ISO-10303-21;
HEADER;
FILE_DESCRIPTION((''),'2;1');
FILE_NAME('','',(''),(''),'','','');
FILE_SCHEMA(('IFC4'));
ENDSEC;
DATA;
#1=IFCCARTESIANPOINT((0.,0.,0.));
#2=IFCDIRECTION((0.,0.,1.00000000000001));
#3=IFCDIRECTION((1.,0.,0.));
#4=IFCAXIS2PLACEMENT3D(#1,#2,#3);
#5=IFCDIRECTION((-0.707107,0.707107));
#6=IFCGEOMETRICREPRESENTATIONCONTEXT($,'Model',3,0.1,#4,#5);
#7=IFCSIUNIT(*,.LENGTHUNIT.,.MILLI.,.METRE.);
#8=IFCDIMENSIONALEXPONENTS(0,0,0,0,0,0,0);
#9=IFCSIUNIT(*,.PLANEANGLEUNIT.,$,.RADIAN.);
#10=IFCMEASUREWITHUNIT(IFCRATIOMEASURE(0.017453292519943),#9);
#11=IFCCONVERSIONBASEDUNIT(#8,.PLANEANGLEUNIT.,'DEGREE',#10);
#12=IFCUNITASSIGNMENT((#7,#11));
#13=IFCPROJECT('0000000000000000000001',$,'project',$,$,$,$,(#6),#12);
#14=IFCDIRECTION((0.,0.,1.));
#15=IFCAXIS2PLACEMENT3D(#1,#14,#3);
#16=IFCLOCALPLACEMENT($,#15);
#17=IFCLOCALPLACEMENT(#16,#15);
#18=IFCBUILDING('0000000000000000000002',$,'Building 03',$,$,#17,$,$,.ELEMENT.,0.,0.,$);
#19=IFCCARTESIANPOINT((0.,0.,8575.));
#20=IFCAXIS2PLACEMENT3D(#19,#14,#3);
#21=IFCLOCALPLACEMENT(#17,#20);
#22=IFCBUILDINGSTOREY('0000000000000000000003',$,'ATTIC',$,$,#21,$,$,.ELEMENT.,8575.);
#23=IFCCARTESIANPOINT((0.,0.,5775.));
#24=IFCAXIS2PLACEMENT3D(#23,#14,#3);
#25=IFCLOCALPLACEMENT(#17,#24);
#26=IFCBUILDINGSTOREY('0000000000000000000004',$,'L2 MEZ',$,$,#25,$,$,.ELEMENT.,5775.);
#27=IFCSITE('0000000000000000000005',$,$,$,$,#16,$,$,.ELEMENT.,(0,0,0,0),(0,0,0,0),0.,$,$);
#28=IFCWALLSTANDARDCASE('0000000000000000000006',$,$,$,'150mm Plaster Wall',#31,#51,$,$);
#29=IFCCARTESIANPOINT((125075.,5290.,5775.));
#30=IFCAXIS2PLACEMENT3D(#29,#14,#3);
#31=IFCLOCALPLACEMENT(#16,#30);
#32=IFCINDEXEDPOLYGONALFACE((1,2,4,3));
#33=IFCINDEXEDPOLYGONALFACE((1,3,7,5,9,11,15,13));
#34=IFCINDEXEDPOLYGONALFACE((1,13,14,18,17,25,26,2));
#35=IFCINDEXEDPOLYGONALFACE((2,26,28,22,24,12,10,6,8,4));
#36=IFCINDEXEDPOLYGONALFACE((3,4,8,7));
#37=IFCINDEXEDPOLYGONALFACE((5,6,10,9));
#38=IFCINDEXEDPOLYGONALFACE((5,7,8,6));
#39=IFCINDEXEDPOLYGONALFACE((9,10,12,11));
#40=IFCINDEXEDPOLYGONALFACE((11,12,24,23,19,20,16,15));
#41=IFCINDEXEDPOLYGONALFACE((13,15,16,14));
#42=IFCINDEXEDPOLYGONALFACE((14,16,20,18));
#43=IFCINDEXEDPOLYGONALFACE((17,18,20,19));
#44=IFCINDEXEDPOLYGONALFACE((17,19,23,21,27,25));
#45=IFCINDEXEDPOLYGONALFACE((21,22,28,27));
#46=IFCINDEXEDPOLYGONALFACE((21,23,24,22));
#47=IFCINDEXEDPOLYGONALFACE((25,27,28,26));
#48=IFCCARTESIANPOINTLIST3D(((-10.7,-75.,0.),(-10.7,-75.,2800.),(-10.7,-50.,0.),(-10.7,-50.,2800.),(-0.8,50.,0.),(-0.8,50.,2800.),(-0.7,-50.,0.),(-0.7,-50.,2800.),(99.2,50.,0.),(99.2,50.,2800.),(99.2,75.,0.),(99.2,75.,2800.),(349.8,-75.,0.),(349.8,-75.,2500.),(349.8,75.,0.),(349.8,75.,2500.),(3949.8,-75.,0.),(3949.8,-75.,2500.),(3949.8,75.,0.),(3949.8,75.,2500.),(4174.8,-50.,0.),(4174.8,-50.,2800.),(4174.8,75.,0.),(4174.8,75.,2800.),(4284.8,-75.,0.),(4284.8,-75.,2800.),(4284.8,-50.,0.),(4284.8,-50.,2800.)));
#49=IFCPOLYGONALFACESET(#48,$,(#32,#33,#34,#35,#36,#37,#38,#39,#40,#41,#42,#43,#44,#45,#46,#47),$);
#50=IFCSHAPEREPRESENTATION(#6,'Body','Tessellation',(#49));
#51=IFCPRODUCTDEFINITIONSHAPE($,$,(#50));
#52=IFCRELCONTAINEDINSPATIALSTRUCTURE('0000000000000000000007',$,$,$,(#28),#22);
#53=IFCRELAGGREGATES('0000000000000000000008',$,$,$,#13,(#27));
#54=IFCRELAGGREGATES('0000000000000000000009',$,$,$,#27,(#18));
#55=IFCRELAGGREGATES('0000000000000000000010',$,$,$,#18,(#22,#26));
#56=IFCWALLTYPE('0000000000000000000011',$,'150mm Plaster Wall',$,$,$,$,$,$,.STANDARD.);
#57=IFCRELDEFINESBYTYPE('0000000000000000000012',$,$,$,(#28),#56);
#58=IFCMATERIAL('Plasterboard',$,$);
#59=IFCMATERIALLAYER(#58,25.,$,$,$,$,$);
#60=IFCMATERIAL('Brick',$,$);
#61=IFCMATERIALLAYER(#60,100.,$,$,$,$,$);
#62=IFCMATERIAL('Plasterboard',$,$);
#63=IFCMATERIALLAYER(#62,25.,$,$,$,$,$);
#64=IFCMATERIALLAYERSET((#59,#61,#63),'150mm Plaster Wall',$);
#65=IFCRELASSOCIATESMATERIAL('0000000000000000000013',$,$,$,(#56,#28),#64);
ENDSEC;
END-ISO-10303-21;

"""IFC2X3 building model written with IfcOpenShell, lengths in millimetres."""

from ifc_helpers import new_model, entity, si_unit, converted_unit, direction, frame, origin_with_axes, place, context, project, spatial, polyline, outline, extrude, material, layer, layer_set, layer_usage, type_object, element, save


model = new_model("IFC2X3")

# Units and contexts
model_context = context("Model", 3, precision=0.1, world=frame((0.0, 0.0, 0.0), z_axis=(0.0, 0.0, 1.00000000000001), x_axis=(1.0, 0.0, 0.0)), true_north=direction((-0.707107, 0.707107)))
ifc_project = project(units=[si_unit("LENGTHUNIT", "METRE", prefix="MILLI"), converted_unit("PLANEANGLEUNIT", "DEGREE", entity("IfcRatioMeasure", 0.017453292519943), si_unit("PLANEANGLEUNIT", "RADIAN"), dimensions=[0, 0, 0, 0, 0, 0, 0])], contexts=[model_context])

# Site, building, storey
site_placement = place(None, origin_with_axes())
site = spatial("IfcSite", under=ifc_project, at=site_placement, CompositionType="ELEMENT", RefLatitude=(0, 0, 0, 0), RefLongitude=(0, 0, 0, 0), RefElevation=0.0)
building_placement = place(site_placement, origin_with_axes())
building = spatial("IfcBuilding", under=site, at=building_placement, Name="Building 03", CompositionType="ELEMENT", ElevationOfRefHeight=0.0, ElevationOfTerrain=0.0)
storey_1_placement = place(building_placement, frame((0.0, 0.0, 8575.0), z_axis=(0.0, 0.0, 1.0), x_axis=(1.0, 0.0, 0.0)))
storey_1 = spatial("IfcBuildingStorey", under=building, at=storey_1_placement, Name="ATTIC", CompositionType="ELEMENT", Elevation=8575.0)

# Shared definitions
storey_2_placement = place(building_placement, frame((0.0, 0.0, 5775.0), z_axis=(0.0, 0.0, 1.0), x_axis=(1.0, 0.0, 0.0)))
storey_2 = spatial("IfcBuildingStorey", under=building, at=storey_2_placement, Name="L2 MEZ", CompositionType="ELEMENT", Elevation=5775.0)

# Wall, opening
ifc_material_1 = material(Name="Plasterboard")
ifc_layer_1 = layer(ifc_material_1, 25.0)
ifc_material_2 = material(Name="Brick")
ifc_layer_2 = layer(ifc_material_2, 100.0)
ifc_material_3 = material(Name="Plasterboard")
ifc_layer_3 = layer(ifc_material_3, 25.0)
ifc_layer_set_1 = layer_set([ifc_layer_1, ifc_layer_2, ifc_layer_3], Name="150mm Plaster Wall")
ifc_layer_usage_1 = layer_usage(ifc_layer_set_1, "AXIS2", "POSITIVE", -75.0)
wall_type_1 = type_object("IfcWallType", Name="150mm Plaster Wall", PredefinedType="STANDARD", material=ifc_layer_set_1)
wall_1_placement = place(site_placement, frame((125075.0, 5290.0, 5775.0), z_axis=(0.0, 0.0, 1.0), x_axis=(1.0, 0.0, 0.0)))
wall_1 = element("IfcWallStandardCase", 1, at=wall_1_placement, inside=storey_1, type_object=wall_type_1, material=ifc_layer_usage_1, ObjectType="150mm Plaster Wall", context=model_context, shape_type="SweptSolid", body=[
    extrude(outline(polyline([(4174.8, 75.0), (4174.8, -50.0), (4284.8, -50.0), (4284.8, -75.0), (-10.7, -75.0), (-10.7, -50.0), (-0.7, -50.0), (-0.8, 50.0), (99.2, 50.0), (99.2, 75.0), (4174.8, 75.0)])), origin_with_axes(), (0.0, 0.0, 1.0), 2800.0),
])
opening_1_placement = place(wall_1_placement, frame((2149.8, 0.0, 0.0), z_axis=(0.0, 0.0, 1.0), x_axis=(1.0, 0.0, 0.0)))
element("IfcOpeningElement", 2, at=opening_1_placement, cuts=wall_1, ObjectType="Opening", context=model_context, shape_type="SweptSolid", body=[
    extrude(outline(polyline([(-1800.0, -1250.0), (1800.0, -1250.0), (1800.0, 1250.0), (-1800.0, 1250.0), (-1800.0, -1250.0)])), frame((0.0, 150.0, 1250.0), z_axis=(0.0, -1.0, 0.0), x_axis=(1.0, 0.0, 0.0)), (0.0, 0.0, 1.0), 300.0),
])

save(model, "model.ifc")
